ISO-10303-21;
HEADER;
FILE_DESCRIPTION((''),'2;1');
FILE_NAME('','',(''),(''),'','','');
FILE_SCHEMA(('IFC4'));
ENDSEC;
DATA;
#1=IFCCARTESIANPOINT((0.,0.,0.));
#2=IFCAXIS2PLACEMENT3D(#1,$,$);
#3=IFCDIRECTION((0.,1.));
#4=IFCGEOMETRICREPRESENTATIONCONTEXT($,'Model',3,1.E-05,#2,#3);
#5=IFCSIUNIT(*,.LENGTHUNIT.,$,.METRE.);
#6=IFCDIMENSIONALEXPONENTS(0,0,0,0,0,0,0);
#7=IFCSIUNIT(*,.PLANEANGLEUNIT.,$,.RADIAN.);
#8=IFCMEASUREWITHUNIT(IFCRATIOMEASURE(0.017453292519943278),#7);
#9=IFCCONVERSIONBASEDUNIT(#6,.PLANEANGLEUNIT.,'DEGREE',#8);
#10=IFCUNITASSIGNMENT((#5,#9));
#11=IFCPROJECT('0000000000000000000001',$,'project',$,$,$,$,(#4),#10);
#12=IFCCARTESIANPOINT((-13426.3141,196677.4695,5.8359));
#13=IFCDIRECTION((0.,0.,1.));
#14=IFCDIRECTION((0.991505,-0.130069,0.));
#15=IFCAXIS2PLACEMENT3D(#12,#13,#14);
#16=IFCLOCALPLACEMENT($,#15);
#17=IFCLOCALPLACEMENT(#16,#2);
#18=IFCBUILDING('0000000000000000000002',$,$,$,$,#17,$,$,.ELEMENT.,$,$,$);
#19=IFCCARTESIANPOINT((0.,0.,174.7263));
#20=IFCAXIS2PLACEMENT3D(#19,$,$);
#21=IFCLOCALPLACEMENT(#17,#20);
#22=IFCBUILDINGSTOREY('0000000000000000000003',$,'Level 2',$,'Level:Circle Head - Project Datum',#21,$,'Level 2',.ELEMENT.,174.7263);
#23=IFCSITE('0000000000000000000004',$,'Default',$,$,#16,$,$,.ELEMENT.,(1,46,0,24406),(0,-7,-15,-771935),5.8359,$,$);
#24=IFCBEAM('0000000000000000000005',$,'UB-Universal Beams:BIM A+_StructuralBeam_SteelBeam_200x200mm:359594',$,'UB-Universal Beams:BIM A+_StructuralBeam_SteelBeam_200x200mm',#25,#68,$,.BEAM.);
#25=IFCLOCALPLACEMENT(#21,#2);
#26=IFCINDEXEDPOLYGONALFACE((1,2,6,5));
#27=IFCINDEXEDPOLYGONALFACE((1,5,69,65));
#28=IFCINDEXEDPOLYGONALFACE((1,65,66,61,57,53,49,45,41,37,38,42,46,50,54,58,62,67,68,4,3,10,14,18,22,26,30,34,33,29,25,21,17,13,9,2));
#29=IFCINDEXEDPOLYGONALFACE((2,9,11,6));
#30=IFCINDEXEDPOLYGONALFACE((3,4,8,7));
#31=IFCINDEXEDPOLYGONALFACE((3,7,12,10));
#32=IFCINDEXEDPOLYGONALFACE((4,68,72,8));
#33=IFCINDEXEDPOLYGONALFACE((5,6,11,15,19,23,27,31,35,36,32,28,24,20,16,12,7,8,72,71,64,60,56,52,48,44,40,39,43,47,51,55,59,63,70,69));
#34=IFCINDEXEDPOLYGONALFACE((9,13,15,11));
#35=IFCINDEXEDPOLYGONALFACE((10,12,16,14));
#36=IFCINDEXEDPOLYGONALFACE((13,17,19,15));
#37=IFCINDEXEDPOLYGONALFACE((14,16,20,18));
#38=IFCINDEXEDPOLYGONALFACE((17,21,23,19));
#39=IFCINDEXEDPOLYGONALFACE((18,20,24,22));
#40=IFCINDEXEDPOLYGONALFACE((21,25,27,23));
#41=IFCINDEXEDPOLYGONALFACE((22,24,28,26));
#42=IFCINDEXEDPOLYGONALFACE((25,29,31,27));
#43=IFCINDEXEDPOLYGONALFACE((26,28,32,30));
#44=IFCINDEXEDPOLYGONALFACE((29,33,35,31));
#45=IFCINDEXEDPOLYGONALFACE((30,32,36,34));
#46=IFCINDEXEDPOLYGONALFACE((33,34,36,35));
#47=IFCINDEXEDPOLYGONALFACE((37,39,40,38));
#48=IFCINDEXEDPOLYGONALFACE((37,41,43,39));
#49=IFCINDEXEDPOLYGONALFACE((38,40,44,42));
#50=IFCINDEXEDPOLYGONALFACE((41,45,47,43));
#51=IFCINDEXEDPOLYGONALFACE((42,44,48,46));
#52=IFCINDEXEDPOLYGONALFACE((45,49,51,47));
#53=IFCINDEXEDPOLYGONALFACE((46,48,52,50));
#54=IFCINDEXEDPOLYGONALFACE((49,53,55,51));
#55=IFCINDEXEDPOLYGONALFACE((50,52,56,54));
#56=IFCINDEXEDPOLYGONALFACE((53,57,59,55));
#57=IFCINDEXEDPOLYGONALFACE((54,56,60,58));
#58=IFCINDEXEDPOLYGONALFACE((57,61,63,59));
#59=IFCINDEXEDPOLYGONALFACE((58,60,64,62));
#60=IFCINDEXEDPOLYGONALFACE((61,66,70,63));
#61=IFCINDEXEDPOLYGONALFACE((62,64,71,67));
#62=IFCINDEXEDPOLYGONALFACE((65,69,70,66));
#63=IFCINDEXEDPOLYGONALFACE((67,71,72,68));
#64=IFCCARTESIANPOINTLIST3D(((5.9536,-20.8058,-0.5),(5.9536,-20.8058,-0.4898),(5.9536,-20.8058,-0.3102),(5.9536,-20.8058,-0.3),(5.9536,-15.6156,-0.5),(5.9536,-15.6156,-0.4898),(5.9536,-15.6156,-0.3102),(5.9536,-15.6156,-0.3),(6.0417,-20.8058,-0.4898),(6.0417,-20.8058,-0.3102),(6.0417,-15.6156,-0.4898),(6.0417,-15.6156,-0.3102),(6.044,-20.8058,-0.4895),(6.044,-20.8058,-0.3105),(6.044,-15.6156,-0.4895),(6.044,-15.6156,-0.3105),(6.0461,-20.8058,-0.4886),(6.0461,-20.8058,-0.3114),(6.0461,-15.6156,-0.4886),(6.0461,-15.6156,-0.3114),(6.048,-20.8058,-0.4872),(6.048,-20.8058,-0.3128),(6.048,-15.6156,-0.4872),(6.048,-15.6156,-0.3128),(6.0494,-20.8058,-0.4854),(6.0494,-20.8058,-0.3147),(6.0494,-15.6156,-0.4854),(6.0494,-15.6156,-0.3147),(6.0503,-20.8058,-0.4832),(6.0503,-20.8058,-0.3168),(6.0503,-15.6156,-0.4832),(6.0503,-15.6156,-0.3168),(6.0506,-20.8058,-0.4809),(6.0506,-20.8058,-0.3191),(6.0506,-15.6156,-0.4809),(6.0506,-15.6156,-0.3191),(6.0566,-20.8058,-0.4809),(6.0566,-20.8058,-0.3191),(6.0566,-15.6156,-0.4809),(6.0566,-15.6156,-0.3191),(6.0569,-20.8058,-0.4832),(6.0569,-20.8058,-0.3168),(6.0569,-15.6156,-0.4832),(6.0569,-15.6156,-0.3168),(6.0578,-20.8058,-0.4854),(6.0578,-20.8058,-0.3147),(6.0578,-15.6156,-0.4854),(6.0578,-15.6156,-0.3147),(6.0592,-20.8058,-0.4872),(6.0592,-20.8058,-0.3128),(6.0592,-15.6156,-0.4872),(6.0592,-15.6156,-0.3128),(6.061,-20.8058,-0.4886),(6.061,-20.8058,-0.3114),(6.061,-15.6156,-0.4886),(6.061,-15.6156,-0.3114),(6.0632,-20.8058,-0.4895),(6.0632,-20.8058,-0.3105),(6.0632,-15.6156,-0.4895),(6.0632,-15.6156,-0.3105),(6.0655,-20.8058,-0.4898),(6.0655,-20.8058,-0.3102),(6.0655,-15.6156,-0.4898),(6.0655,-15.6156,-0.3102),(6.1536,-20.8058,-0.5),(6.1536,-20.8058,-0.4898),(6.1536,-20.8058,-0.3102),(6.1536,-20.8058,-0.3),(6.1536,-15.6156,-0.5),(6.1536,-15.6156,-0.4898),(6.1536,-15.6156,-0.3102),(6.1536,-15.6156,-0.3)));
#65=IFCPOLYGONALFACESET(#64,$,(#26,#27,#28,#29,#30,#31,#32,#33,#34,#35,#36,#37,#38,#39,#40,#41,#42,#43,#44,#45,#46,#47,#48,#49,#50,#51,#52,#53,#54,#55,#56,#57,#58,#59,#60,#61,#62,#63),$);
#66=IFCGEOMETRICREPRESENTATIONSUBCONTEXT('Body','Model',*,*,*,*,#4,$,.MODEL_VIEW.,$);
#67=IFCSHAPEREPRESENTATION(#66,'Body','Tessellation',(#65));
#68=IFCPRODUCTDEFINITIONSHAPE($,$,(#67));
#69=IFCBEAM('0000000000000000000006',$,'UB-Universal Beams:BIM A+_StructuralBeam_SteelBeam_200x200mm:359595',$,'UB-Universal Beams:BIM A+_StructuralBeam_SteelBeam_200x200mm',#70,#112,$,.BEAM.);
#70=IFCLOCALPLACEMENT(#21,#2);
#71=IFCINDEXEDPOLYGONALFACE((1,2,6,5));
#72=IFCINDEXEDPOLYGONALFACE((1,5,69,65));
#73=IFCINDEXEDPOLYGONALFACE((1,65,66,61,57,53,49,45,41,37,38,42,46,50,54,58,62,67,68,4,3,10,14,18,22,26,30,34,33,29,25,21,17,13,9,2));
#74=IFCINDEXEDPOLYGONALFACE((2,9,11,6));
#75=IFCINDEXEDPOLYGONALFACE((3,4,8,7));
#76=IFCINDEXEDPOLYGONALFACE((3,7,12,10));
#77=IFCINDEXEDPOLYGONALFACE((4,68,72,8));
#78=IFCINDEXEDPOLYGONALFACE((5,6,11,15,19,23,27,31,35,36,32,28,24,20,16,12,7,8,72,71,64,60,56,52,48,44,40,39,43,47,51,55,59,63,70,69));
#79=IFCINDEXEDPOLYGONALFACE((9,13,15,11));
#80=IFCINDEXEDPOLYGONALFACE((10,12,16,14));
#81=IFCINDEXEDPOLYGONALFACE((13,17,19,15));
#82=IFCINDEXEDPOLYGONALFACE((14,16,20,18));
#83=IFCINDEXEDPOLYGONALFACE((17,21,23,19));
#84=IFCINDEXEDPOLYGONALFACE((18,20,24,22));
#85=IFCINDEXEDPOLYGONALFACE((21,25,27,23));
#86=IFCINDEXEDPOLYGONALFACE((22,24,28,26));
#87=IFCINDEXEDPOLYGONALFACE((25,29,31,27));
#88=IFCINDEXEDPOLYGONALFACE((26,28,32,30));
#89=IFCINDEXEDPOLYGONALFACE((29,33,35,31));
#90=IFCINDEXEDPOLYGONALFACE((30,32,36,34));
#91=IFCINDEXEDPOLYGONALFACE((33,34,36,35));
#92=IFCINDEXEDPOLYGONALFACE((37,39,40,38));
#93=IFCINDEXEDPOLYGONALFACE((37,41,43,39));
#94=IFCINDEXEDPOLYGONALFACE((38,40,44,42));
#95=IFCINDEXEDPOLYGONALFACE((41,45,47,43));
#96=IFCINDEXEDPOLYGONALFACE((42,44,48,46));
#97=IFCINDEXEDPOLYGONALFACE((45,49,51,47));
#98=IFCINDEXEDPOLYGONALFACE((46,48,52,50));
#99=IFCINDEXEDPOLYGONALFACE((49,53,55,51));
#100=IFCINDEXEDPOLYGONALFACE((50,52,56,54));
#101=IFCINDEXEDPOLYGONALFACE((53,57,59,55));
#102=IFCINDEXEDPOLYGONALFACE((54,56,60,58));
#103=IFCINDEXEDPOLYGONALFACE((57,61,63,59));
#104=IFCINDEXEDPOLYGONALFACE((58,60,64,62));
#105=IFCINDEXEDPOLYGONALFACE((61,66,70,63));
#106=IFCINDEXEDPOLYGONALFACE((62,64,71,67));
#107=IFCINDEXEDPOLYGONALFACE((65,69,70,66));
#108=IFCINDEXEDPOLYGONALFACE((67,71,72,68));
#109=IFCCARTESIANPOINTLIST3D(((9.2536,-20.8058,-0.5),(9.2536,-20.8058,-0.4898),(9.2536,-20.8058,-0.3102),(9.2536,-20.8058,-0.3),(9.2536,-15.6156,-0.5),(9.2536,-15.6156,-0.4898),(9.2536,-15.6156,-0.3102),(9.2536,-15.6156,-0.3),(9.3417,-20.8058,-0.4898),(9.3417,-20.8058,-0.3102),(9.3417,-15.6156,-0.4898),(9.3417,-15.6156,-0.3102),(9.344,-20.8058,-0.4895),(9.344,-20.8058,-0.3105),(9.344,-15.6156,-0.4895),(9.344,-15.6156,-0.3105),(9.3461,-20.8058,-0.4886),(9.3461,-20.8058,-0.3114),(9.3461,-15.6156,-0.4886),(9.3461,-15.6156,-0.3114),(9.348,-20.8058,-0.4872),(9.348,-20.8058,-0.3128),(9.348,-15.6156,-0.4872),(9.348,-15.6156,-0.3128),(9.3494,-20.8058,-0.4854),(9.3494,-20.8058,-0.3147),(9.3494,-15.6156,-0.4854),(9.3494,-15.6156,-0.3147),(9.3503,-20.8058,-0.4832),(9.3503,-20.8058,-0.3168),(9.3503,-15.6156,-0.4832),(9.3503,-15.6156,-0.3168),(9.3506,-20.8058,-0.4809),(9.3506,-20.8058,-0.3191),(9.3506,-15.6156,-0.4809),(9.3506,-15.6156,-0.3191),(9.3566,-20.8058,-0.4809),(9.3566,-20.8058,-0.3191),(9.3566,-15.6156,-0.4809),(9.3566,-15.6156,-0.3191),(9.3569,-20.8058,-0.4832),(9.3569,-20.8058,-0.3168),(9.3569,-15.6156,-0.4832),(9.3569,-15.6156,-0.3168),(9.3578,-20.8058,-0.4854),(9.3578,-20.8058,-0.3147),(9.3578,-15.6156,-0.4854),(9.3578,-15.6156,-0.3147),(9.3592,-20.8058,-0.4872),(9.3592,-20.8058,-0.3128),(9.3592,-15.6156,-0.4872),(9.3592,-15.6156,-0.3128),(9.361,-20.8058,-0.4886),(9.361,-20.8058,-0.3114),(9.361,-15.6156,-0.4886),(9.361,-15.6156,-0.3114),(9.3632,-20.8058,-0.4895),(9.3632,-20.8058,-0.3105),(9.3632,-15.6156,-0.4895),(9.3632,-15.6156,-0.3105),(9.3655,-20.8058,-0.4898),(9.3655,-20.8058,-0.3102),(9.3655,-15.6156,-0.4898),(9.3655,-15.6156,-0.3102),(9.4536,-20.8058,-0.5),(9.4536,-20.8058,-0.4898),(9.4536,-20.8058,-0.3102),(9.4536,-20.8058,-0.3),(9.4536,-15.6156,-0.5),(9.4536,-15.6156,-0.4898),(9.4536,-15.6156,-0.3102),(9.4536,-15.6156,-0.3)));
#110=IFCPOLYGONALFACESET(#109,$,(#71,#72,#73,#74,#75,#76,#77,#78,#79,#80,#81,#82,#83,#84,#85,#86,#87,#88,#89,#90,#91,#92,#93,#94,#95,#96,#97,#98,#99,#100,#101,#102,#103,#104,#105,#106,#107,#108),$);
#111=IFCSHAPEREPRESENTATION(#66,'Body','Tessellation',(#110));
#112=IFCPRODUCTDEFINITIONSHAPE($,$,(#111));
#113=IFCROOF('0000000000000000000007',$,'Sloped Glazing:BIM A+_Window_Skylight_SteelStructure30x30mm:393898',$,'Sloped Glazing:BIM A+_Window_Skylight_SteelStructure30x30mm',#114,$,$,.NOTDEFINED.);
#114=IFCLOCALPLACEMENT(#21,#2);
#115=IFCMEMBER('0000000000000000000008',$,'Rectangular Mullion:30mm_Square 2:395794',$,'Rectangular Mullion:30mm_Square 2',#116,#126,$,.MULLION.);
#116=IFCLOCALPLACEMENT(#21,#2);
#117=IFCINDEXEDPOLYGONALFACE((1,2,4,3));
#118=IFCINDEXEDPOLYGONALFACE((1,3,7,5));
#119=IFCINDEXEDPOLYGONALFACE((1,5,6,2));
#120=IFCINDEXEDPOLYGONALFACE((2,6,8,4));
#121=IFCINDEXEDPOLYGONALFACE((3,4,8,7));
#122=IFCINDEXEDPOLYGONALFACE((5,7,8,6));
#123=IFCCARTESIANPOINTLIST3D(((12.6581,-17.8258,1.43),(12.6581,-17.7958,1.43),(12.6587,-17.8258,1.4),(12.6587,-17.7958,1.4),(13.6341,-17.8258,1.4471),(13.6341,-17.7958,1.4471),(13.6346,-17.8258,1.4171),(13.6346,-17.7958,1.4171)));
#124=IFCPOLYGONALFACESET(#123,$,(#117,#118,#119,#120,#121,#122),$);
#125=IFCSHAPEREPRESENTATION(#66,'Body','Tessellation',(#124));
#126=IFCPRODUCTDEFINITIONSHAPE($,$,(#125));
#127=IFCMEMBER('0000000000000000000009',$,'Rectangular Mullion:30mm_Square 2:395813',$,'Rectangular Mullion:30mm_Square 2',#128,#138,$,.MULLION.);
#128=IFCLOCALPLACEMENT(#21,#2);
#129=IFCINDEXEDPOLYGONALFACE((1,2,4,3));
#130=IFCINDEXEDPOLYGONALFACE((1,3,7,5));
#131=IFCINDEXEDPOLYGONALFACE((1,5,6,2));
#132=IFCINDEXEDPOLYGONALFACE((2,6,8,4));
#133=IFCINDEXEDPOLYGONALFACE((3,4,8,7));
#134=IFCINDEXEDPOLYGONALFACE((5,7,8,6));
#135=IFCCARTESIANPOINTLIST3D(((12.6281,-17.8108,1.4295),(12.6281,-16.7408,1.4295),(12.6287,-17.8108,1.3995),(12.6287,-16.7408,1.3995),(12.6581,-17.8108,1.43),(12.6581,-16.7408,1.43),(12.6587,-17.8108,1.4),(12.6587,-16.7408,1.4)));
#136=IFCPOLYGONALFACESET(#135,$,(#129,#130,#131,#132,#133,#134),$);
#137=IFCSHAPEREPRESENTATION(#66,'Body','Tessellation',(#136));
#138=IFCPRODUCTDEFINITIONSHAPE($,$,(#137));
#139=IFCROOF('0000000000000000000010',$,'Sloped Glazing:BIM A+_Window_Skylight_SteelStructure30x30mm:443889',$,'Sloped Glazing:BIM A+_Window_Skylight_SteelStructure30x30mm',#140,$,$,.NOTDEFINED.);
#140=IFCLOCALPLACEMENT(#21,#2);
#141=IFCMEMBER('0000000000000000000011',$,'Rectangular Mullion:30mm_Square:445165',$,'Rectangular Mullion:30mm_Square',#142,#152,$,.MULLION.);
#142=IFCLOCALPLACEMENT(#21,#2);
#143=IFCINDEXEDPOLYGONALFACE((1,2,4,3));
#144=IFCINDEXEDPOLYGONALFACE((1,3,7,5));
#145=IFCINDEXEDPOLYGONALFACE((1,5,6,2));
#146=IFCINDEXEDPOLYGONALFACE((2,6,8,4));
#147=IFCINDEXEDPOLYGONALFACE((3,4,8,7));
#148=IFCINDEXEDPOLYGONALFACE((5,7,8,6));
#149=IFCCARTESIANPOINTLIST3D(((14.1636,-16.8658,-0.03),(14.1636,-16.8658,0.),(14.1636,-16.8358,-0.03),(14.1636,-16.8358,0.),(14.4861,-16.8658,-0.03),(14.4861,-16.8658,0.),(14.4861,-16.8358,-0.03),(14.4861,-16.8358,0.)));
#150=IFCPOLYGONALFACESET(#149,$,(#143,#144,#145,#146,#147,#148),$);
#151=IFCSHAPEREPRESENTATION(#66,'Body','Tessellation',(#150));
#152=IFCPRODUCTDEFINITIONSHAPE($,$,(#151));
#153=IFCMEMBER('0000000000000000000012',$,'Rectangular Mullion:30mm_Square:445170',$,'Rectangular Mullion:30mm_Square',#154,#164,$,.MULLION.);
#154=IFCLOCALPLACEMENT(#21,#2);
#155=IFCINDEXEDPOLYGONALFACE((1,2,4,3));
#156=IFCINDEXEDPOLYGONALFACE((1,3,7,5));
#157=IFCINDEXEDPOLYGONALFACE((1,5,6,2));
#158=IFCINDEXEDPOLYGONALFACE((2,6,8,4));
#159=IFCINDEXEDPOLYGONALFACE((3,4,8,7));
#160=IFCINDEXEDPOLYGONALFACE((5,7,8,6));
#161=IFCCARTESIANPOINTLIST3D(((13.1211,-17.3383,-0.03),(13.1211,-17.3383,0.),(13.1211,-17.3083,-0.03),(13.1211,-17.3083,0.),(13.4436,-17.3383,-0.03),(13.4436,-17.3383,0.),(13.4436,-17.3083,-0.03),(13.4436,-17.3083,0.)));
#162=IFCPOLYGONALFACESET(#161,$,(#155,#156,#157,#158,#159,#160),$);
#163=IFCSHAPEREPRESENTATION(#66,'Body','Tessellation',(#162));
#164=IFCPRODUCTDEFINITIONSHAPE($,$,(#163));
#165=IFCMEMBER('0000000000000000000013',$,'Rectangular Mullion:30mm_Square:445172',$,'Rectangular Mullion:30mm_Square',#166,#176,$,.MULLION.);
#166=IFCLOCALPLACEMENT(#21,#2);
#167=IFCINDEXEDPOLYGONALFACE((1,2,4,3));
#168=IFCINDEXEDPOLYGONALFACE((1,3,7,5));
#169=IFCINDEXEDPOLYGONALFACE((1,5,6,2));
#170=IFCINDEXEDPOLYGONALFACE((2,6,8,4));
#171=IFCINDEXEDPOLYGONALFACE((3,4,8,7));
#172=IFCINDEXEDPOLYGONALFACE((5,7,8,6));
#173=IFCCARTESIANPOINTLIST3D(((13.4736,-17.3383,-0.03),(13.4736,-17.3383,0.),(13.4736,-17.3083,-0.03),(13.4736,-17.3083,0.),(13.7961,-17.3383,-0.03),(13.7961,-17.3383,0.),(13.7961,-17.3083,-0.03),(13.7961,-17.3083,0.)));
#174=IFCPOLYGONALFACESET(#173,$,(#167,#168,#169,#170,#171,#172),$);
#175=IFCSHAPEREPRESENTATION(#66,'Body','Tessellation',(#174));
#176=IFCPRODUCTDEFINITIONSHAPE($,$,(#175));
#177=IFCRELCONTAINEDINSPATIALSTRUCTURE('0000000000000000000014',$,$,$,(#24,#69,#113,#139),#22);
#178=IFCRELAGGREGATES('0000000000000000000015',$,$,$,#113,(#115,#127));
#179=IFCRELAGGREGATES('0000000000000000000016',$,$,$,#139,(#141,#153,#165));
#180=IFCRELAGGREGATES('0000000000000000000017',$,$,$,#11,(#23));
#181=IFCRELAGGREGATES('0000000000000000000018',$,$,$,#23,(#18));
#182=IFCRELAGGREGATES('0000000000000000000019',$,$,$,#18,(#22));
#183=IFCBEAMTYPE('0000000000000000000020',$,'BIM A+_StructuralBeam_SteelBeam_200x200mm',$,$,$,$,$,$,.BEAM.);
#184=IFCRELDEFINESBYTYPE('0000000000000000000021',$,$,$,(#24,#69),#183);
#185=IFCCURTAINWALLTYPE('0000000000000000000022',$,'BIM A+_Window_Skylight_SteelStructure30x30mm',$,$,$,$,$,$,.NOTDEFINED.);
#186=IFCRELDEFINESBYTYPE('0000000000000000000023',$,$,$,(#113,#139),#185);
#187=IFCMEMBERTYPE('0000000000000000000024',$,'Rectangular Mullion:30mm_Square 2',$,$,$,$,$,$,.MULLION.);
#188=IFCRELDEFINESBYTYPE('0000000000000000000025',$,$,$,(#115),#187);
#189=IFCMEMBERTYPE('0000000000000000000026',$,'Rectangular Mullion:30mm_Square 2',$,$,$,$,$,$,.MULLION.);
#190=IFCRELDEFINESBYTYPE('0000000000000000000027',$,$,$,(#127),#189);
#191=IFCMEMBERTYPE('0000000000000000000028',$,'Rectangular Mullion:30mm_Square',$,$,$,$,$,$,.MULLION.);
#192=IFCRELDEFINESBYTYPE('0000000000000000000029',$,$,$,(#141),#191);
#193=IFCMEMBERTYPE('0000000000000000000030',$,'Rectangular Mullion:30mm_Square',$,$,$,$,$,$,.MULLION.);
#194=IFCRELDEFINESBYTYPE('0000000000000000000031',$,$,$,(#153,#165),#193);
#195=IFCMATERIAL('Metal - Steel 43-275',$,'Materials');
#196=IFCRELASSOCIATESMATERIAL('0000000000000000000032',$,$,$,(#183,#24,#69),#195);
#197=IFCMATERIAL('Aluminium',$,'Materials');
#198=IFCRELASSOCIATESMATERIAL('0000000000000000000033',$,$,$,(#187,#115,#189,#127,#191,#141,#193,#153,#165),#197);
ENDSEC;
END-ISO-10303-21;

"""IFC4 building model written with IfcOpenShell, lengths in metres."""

from ifc_helpers import new_model, entity, si_unit, converted_unit, direction, frame, origin, place, context, subcontext, project, spatial, line, arc, indexed_curve, outline, extrude, source, transform, mapped, material, type_object, type_shapes, element, aggregate, save


model = new_model("IFC4")

# Units and contexts
model_context = context("Model", 3, precision=1e-05, world=origin(), true_north=direction((0.0, 1.0)))
body_context = subcontext(model_context, "Body", "Model", "MODEL_VIEW")
ifc_project = project(units=[si_unit("LENGTHUNIT", "METRE"), converted_unit("PLANEANGLEUNIT", "DEGREE", entity("IfcRatioMeasure", 0.017453292519943278), si_unit("PLANEANGLEUNIT", "RADIAN"), dimensions=[0, 0, 0, 0, 0, 0, 0])], contexts=[model_context])

# Site, building, storey
site_placement = place(None, frame((-13426.3141, 196677.4695, 5.8359), z_axis=(0.0, 0.0, 1.0), x_axis=(0.991505, -0.130069, 0.0)))
site = spatial("IfcSite", under=ifc_project, at=site_placement, Name="Default", CompositionType="ELEMENT", RefLatitude=(1, 46, 0, 24406), RefLongitude=(0, -7, -15, -771935), RefElevation=5.8359)
building_placement = place(site_placement, origin())
building = spatial("IfcBuilding", under=site, at=building_placement, CompositionType="ELEMENT")
storey_placement = place(building_placement, frame((0.0, 0.0, 174.7263)))
storey = spatial("IfcBuildingStorey", under=building, at=storey_placement, Name="Level 2", ObjectType="Level:Circle Head - Project Datum", LongName="Level 2", CompositionType="ELEMENT", Elevation=174.7263)

# Beams
ifc_material_1 = material(Name="Metal - Steel 43-275", Category="Materials")
beam_type = type_object("IfcBeamType", Name="BIM A+_StructuralBeam_SteelBeam_200x200mm", PredefinedType="BEAM", material=ifc_material_1)
shared_shape_1 = source(origin(), body_context, "Body", "SweptSolid", [
    extrude(outline(indexed_curve([(-0.1, -0.1), (-0.0898, -0.1), (-0.0898, -0.0119), (-0.0872, -0.0056), (-0.0809, -0.003), (0.0809, -0.003), (0.0872, -0.0056), (0.0898, -0.0119), (0.0898, -0.1), (0.1, -0.1), (0.1, 0.1), (0.0898, 0.1), (0.0898, 0.0119), (0.0872, 0.0056), (0.0809, 0.003), (-0.0809, 0.003), (-0.0872, 0.0056), (-0.0898, 0.0119), (-0.0898, 0.1), (-0.1, 0.1)], segments=[line(1, 2, 3), arc(3, 4, 5), line(5, 6), arc(6, 7, 8), line(8, 9, 10, 11, 12, 13), arc(13, 14, 15), line(15, 16), arc(16, 17, 18), line(18, 19, 20, 1)], self_intersect=False)), frame((-2.5452, 0.0, 0.0), z_axis=(1.0, 0.0, 0.0), x_axis=(0.0, 0.0, -1.0)), (0.0, 0.0, 1.0), 5.1902),
])
type_shapes(beam_type, [shared_shape_1])
for number, where, z_axis, x_axis, name in (
    (1, (6.0536, -18.1608, -0.4), (0.0, 0.0, 1.0), (0.0, -1.0, 0.0), "UB-Universal Beams:BIM A+_StructuralBeam_SteelBeam_200x200mm:359594"),
    (2, (9.3536, -18.1608, -0.4), (0.0, 0.0, 1.0), (0.0, -1.0, 0.0), "UB-Universal Beams:BIM A+_StructuralBeam_SteelBeam_200x200mm:359595"),
):
    element("IfcBeam", number, at=place(storey_placement, frame(where, z_axis=z_axis, x_axis=x_axis)), inside=storey, type_object=beam_type, material=ifc_material_1, Name=name, ObjectType="UB-Universal Beams:BIM A+_StructuralBeam_SteelBeam_200x200mm", PredefinedType="BEAM", context=body_context, shape_type="MappedRepresentation", body=[
        mapped(shared_shape_1, transform((0.0, 0.0, 0.0), scale=1.0)),
    ])

# Roofs, members
curtain_wall_type = type_object("IfcCurtainWallType", Name="BIM A+_Window_Skylight_SteelStructure30x30mm", PredefinedType="NOTDEFINED")
roof_1_placement = place(storey_placement, frame((0.0, 0.0, -174.7263)))
roof_1 = element("IfcRoof", 3, at=roof_1_placement, inside=storey, type_object=curtain_wall_type, Name="Sloped Glazing:BIM A+_Window_Skylight_SteelStructure30x30mm:393898", ObjectType="Sloped Glazing:BIM A+_Window_Skylight_SteelStructure30x30mm", PredefinedType="NOTDEFINED")
ifc_material_2 = material(Name="Aluminium", Category="Materials")
member_type_1 = type_object("IfcMemberType", Name="Rectangular Mullion:30mm_Square 2", PredefinedType="MULLION", material=ifc_material_2)
shared_shape_2 = source(origin(), body_context, "Body", "SweptSolid", [
    extrude(outline(indexed_curve([(-0.015, -0.015), (0.015, -0.015), (0.015, 0.015), (-0.015, 0.015), (-0.015, -0.015)], self_intersect=False)), frame((0.0, -0.0095, -0.9761), z_axis=(0.0, 0.0, 1.0), x_axis=(0.0, -1.0, 0.0)), (0.0, 0.0, 1.0), 0.9761),
])
type_shapes(member_type_1, [shared_shape_2])
member_1_placement = place(roof_1_placement, frame((12.6586, -17.8108, 176.1318), z_axis=(-0.999848, 0.0, -0.017452), x_axis=(0.0, 1.0, 0.0)))
member_1 = element("IfcMember", 4, at=member_1_placement, type_object=member_type_1, material=ifc_material_2, Name="Rectangular Mullion:30mm_Square 2:395794", ObjectType="Rectangular Mullion:30mm_Square 2", PredefinedType="MULLION", context=body_context, shape_type="MappedRepresentation", body=[
    mapped(shared_shape_2, transform((0.0, 0.0, 0.0), scale=1.0)),
])
member_type_2 = type_object("IfcMemberType", Name="Rectangular Mullion:30mm_Square 2", PredefinedType="MULLION", material=ifc_material_2)
shared_shape_3 = source(origin(), body_context, "Body", "SweptSolid", [
    extrude(outline(indexed_curve([(-0.015, -0.015), (0.015, -0.015), (0.015, 0.015), (-0.015, 0.015), (-0.015, -0.015)], self_intersect=False)), frame((-0.015, -0.0095, -1.07), z_axis=(0.0, 0.0, 1.0), x_axis=(0.0, -1.0, 0.0)), (0.0, 0.0, 1.0), 1.07),
])
type_shapes(member_type_2, [shared_shape_3])
member_2_placement = place(roof_1_placement, frame((12.6286, -17.8108, 176.1313), z_axis=(0.0, -1.0, 0.0), x_axis=(-0.999848, 0.0, -0.017452)))
member_2 = element("IfcMember", 5, at=member_2_placement, type_object=member_type_2, material=ifc_material_2, Name="Rectangular Mullion:30mm_Square 2:395813", ObjectType="Rectangular Mullion:30mm_Square 2", PredefinedType="MULLION", context=body_context, shape_type="MappedRepresentation", body=[
    mapped(shared_shape_3, transform((0.0, 0.0, 0.0), scale=1.0)),
])
roof_2_placement = place(storey_placement, frame((0.0, 0.0, -174.7263)))
roof_2 = element("IfcRoof", 6, at=roof_2_placement, inside=storey, type_object=curtain_wall_type, Name="Sloped Glazing:BIM A+_Window_Skylight_SteelStructure30x30mm:443889", ObjectType="Sloped Glazing:BIM A+_Window_Skylight_SteelStructure30x30mm", PredefinedType="NOTDEFINED")
member_type_3 = type_object("IfcMemberType", Name="Rectangular Mullion:30mm_Square", PredefinedType="MULLION", material=ifc_material_2)
shared_shape_4 = source(origin(), body_context, "Body", "SweptSolid", [
    extrude(outline(indexed_curve([(-0.015, -0.015), (0.015, -0.015), (0.015, 0.015), (-0.015, 0.015), (-0.015, -0.015)], self_intersect=False)), frame((-0.015, 0.0, -0.3225), z_axis=(0.0, 0.0, 1.0), x_axis=(0.0, -1.0, 0.0)), (0.0, 0.0, 1.0), 0.3225),
])
type_shapes(member_type_3, [shared_shape_4])
member_3_placement = place(roof_2_placement, frame((14.1636, -16.8358, 174.7113), z_axis=(-1.0, 0.0, 0.0), x_axis=(0.0, 1.0, 0.0)))
member_3 = element("IfcMember", 7, at=member_3_placement, type_object=member_type_3, material=ifc_material_2, Name="Rectangular Mullion:30mm_Square:445165", ObjectType="Rectangular Mullion:30mm_Square", PredefinedType="MULLION", context=body_context, shape_type="MappedRepresentation", body=[
    mapped(shared_shape_4, transform((0.0, 0.0, 0.0), scale=1.0)),
])
member_type_4 = type_object("IfcMemberType", Name="Rectangular Mullion:30mm_Square", PredefinedType="MULLION", material=ifc_material_2)
shared_shape_5 = source(origin(), body_context, "Body", "SweptSolid", [
    extrude(outline(indexed_curve([(-0.015, -0.015), (0.015, -0.015), (0.015, 0.015), (-0.015, 0.015), (-0.015, -0.015)], self_intersect=False)), frame((0.0, 0.0, -0.3225), z_axis=(0.0, 0.0, 1.0), x_axis=(0.0, -1.0, 0.0)), (0.0, 0.0, 1.0), 0.3225),
])
type_shapes(member_type_4, [shared_shape_5])
member_4_placement = place(roof_2_placement, frame((13.4436, -17.3233, 174.7113), z_axis=(1.0, 0.0, 0.0), x_axis=(0.0, -1.0, 0.0)))
member_4 = element("IfcMember", 8, at=member_4_placement, type_object=member_type_4, material=ifc_material_2, Name="Rectangular Mullion:30mm_Square:445170", ObjectType="Rectangular Mullion:30mm_Square", PredefinedType="MULLION", context=body_context, shape_type="MappedRepresentation", body=[
    mapped(shared_shape_5, transform((0.0, 0.0, 0.0), scale=1.0)),
])
member_5_placement = place(roof_2_placement, frame((13.7961, -17.3233, 174.7113), z_axis=(1.0, 0.0, 0.0), x_axis=(0.0, -1.0, 0.0)))
member_5 = element("IfcMember", 9, at=member_5_placement, type_object=member_type_4, material=ifc_material_2, Name="Rectangular Mullion:30mm_Square:445172", ObjectType="Rectangular Mullion:30mm_Square", PredefinedType="MULLION", context=body_context, shape_type="MappedRepresentation", body=[
    mapped(shared_shape_5, transform((0.0, 0.0, 0.0), scale=1.0)),
])

aggregate(roof_1, [member_1, member_2])
aggregate(roof_2, [member_3, member_4, member_5])

save(model, "model.ifc")
